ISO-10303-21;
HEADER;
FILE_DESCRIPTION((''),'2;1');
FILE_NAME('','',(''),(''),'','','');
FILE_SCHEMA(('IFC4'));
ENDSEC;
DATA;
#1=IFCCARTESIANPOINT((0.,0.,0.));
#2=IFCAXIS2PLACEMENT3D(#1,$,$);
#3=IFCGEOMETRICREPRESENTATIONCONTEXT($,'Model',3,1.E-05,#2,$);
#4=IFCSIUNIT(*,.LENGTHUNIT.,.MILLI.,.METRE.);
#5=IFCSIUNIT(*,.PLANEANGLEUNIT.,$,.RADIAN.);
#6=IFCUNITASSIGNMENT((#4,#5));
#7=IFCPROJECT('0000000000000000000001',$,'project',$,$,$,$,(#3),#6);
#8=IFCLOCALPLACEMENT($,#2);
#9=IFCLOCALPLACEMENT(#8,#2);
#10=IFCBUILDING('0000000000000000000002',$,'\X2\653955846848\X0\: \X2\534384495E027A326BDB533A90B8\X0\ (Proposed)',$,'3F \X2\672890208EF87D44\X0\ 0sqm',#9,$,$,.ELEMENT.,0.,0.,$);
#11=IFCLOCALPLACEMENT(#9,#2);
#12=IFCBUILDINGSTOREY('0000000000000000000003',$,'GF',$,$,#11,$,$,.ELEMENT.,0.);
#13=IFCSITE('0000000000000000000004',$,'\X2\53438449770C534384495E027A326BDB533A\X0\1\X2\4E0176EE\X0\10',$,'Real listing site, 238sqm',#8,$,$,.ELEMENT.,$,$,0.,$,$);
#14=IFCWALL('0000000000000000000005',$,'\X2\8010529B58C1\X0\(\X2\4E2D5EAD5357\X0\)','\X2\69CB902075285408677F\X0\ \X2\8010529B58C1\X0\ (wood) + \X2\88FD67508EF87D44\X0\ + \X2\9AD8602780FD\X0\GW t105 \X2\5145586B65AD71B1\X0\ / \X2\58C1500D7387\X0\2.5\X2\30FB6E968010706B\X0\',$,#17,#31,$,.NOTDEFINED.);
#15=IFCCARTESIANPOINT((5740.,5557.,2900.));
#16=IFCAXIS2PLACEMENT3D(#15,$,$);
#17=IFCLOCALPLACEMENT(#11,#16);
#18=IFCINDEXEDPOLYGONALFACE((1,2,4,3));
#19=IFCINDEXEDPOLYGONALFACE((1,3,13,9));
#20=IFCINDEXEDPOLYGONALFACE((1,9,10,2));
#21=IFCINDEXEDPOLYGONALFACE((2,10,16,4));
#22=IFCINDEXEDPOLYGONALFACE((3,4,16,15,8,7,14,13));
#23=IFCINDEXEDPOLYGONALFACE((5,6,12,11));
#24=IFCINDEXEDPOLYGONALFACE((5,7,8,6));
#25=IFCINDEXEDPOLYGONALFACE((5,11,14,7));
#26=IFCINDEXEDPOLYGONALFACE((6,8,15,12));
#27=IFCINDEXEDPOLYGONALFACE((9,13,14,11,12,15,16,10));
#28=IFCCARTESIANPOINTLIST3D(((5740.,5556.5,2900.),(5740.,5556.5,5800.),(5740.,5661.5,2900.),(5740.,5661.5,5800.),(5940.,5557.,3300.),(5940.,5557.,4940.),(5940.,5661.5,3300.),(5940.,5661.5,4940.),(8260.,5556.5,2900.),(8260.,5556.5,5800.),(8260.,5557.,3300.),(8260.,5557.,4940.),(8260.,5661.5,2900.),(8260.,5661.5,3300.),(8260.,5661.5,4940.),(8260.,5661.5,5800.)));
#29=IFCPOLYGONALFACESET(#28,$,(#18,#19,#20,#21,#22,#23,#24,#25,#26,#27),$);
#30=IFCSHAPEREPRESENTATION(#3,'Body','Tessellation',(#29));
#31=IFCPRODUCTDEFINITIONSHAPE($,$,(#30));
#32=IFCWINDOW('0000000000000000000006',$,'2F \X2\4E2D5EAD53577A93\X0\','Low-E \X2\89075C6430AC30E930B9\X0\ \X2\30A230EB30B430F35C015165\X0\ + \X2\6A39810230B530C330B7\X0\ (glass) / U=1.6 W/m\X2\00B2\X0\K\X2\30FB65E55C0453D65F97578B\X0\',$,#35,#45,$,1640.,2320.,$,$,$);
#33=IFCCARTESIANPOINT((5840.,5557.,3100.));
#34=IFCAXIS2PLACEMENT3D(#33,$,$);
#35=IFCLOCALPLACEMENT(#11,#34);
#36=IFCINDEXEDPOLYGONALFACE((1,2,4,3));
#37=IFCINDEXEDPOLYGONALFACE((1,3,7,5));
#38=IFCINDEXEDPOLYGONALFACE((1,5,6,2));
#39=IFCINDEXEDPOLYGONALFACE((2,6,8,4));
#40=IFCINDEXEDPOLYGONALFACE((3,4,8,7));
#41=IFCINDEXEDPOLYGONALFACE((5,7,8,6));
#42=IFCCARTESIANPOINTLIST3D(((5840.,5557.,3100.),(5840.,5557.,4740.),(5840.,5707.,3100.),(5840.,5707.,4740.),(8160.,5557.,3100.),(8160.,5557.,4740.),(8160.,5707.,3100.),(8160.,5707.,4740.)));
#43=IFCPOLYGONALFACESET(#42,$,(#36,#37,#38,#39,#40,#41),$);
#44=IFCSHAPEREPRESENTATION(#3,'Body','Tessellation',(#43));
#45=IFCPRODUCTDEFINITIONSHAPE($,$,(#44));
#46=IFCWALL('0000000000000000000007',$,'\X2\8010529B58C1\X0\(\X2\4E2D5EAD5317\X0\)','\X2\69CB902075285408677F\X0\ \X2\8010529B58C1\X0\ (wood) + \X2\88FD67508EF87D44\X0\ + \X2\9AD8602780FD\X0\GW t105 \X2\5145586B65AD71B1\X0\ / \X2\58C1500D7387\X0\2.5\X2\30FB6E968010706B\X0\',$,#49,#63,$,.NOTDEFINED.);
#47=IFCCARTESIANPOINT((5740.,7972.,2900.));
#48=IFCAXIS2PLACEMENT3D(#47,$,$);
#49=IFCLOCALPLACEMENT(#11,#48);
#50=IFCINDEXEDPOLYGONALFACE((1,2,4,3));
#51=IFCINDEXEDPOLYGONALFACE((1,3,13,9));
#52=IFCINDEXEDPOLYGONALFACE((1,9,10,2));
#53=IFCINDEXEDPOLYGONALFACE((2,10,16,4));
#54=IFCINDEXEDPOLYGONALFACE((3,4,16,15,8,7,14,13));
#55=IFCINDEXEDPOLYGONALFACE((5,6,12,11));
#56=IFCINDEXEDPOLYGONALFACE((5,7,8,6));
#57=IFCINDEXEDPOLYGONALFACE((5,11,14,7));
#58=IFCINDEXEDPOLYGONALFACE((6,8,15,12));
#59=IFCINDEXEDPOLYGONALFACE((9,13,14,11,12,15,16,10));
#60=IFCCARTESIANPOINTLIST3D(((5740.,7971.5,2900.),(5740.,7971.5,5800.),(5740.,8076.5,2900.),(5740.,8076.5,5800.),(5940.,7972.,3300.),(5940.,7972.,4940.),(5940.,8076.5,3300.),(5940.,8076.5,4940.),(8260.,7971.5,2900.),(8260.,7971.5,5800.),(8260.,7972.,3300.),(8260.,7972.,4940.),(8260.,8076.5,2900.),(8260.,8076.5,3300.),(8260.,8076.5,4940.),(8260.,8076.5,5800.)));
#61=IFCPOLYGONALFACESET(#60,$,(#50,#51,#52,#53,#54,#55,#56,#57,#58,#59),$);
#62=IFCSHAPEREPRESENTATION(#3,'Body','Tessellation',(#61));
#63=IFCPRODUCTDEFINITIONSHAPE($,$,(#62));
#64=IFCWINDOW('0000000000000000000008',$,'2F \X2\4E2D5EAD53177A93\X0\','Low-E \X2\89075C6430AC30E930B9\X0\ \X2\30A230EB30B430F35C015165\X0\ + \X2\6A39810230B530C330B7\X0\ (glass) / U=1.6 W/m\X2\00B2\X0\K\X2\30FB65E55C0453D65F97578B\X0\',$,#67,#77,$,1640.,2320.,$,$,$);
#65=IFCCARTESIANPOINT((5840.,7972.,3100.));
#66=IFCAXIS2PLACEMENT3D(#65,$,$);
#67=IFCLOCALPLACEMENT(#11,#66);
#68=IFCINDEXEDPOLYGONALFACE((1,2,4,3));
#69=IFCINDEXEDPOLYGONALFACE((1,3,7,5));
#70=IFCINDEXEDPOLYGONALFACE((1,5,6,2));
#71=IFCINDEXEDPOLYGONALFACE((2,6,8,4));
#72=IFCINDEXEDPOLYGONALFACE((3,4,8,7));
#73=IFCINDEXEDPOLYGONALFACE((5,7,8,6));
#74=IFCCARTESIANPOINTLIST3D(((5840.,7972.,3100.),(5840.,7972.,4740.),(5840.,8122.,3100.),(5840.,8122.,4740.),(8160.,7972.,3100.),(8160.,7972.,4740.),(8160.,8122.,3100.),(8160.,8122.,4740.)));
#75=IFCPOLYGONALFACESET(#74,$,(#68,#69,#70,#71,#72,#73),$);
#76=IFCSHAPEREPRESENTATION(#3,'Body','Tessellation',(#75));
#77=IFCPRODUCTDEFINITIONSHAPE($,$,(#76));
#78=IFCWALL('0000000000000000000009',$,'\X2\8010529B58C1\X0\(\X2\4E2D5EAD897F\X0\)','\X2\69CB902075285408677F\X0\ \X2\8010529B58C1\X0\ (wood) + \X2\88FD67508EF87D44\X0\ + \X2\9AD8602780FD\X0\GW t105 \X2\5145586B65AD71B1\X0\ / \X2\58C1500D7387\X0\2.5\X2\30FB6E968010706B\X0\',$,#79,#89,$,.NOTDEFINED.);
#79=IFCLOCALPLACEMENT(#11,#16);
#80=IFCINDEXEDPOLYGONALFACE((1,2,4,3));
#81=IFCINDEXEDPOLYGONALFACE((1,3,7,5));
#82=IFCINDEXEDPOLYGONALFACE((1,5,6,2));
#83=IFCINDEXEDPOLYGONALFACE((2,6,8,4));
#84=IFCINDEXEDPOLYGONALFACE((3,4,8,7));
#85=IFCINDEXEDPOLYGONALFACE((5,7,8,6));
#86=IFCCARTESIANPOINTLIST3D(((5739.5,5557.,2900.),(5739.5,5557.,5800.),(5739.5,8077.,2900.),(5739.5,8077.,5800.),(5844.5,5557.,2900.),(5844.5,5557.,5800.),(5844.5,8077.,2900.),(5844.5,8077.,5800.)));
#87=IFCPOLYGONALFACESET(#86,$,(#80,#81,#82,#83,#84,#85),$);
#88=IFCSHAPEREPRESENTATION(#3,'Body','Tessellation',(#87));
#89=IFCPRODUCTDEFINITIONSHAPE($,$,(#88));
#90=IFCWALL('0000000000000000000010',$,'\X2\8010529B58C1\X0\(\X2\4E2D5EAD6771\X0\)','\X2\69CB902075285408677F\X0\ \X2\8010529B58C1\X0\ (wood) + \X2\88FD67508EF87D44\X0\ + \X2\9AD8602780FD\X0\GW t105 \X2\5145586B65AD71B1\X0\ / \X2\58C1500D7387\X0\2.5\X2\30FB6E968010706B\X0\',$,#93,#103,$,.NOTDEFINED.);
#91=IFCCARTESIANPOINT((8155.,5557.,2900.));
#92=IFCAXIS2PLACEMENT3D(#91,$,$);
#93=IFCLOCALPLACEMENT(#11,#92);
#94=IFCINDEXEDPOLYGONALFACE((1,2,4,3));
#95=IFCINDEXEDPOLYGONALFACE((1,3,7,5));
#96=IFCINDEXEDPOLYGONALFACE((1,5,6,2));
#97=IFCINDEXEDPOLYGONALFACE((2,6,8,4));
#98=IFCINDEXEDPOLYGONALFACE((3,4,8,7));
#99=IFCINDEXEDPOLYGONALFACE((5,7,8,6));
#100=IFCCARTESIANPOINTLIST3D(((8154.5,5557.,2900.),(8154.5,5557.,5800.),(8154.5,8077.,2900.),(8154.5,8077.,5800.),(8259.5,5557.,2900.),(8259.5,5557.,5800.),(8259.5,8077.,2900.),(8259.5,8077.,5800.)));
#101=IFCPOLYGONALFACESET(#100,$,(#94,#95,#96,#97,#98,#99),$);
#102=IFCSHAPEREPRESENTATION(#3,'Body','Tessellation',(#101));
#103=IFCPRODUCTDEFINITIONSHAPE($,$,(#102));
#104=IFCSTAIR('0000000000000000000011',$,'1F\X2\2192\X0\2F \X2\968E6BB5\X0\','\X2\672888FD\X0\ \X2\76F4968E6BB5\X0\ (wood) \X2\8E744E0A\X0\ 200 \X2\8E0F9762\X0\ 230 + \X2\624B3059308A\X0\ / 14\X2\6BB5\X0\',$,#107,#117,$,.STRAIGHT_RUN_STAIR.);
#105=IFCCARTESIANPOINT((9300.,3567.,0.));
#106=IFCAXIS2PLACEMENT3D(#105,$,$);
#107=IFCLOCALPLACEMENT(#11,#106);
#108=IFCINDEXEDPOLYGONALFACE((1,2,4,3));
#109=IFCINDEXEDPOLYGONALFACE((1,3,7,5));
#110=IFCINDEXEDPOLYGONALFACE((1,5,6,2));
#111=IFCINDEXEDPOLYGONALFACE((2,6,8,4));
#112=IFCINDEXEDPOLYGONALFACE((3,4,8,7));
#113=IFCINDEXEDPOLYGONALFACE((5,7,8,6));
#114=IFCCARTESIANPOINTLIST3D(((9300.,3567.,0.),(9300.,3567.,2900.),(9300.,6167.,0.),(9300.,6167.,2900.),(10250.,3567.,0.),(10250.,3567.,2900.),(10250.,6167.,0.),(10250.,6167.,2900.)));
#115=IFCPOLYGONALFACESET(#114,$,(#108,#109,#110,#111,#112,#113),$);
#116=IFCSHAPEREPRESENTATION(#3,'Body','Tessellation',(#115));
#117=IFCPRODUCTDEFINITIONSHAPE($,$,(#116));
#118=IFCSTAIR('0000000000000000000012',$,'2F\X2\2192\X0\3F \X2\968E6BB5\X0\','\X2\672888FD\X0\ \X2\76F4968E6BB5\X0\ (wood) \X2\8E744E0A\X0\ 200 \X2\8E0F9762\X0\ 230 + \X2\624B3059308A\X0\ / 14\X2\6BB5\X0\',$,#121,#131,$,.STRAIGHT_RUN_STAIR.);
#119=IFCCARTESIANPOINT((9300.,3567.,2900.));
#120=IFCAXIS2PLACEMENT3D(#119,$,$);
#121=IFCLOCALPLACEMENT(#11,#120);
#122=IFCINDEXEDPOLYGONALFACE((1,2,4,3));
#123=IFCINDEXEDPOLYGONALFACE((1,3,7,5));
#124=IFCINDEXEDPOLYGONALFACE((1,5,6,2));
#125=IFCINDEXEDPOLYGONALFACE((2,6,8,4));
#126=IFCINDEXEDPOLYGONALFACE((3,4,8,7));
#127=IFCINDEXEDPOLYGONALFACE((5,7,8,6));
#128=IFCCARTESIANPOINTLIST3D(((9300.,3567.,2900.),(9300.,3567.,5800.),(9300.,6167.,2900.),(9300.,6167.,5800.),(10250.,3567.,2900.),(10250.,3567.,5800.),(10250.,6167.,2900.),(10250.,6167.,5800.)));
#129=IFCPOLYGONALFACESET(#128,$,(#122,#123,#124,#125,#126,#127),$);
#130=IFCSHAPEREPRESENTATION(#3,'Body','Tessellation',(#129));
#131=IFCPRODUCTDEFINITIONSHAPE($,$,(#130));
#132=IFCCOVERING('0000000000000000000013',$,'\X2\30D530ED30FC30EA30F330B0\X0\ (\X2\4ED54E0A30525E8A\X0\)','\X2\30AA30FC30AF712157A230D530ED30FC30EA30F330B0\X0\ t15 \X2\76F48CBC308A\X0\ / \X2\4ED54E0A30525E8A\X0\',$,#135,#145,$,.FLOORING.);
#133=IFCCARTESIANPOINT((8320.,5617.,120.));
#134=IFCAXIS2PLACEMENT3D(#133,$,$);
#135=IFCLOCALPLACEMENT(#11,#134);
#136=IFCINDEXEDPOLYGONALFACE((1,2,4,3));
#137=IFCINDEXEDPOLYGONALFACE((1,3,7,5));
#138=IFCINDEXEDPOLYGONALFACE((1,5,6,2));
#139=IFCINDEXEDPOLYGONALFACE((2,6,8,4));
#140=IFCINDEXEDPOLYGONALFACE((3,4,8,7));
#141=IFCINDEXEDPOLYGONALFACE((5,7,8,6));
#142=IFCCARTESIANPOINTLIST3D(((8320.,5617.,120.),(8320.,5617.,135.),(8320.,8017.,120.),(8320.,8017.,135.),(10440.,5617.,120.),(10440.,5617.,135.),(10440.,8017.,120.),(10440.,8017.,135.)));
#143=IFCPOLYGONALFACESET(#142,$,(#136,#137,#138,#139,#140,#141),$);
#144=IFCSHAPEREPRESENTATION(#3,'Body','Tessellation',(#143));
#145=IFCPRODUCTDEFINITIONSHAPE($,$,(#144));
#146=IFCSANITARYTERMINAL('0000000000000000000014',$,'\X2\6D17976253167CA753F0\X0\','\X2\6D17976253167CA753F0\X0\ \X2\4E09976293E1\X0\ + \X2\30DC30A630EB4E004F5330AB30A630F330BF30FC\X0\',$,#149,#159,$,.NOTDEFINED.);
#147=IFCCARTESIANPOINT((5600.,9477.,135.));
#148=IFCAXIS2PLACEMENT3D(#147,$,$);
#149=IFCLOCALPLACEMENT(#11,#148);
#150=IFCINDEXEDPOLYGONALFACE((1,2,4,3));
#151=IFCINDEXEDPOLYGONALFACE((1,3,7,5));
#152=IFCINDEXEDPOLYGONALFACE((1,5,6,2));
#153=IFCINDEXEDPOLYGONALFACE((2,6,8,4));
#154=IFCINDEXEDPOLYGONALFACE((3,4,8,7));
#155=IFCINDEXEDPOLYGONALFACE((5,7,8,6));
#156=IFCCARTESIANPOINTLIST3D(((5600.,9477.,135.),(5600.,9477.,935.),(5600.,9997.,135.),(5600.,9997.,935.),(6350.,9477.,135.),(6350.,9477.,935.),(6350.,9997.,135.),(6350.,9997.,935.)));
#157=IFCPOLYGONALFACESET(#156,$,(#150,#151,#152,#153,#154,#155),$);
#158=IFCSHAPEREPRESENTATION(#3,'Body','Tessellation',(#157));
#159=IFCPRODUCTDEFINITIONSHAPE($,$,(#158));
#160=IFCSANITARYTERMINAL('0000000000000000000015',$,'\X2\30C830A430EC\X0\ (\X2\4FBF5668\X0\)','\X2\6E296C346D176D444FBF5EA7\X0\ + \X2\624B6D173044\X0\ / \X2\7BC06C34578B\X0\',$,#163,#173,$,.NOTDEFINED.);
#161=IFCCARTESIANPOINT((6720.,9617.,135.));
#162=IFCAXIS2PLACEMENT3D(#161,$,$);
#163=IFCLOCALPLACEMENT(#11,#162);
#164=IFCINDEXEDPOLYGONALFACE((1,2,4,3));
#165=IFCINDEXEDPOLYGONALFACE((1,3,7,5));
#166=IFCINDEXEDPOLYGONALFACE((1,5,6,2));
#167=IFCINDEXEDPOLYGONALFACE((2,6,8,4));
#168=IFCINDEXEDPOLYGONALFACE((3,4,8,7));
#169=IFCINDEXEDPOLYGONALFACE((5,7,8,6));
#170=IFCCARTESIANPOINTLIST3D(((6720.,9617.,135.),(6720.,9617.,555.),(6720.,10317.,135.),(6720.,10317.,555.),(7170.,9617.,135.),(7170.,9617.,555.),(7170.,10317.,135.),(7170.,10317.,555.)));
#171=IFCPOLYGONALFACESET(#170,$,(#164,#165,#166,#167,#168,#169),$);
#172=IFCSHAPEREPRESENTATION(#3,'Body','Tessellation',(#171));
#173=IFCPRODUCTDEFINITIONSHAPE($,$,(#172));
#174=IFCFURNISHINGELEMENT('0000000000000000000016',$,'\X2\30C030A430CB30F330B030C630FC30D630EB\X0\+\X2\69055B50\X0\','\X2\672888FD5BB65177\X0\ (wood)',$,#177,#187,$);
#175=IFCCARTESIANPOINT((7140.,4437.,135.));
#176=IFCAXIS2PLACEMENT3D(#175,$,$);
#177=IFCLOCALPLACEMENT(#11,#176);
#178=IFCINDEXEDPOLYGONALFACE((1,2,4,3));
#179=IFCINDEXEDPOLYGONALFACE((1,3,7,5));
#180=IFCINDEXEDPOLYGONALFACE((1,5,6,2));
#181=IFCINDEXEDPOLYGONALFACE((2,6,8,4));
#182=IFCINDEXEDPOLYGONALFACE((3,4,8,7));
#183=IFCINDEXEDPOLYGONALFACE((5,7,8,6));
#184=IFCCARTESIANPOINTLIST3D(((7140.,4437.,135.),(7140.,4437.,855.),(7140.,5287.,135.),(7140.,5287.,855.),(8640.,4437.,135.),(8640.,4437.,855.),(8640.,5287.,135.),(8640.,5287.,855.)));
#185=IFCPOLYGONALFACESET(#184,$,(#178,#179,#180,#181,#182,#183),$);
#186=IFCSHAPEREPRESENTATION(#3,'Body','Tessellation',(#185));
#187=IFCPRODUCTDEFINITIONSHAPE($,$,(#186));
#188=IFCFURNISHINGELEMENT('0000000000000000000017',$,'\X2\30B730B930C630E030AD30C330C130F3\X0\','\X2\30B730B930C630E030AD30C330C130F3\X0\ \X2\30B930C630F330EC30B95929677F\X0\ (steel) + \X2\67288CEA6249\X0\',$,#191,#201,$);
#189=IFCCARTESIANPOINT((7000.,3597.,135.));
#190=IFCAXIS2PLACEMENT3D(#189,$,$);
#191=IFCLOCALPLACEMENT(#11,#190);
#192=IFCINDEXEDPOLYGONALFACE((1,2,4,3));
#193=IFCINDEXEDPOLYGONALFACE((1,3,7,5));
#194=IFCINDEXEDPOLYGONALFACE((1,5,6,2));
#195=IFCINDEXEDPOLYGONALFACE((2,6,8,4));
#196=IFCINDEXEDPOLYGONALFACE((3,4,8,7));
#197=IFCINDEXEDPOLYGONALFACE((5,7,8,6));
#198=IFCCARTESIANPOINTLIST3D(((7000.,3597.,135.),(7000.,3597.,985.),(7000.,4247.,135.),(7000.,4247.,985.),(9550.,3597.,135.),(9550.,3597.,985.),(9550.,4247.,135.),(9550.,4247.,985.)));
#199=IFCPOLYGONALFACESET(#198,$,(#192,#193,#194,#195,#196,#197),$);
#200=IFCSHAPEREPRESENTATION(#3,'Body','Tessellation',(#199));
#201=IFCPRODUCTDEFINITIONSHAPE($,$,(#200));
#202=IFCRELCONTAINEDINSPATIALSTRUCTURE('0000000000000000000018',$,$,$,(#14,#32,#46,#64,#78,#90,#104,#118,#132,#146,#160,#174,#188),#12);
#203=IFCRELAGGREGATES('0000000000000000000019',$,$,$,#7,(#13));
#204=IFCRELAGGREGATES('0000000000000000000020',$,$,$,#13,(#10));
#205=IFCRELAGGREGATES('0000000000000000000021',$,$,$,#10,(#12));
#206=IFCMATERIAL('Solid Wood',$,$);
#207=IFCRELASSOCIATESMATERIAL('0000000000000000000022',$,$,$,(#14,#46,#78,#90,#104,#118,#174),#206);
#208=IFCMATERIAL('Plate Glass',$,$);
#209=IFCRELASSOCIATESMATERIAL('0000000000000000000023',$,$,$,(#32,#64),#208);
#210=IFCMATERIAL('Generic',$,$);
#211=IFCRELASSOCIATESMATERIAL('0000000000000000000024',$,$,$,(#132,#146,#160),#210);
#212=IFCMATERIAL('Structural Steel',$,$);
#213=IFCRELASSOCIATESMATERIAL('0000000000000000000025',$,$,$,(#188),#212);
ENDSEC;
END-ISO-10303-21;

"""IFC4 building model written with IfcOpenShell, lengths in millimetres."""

from ifc_helpers import new_model, si_unit, frame, frame_2d, origin, place, context, project, spatial, rectangle, extrude, material, element, fill, save


model = new_model("IFC4")

# Units and contexts
model_context = context("Model", 3, precision=1e-05, world=origin())
ifc_project = project(units=[si_unit("LENGTHUNIT", "METRE", prefix="MILLI"), si_unit("PLANEANGLEUNIT", "RADIAN")], contexts=[model_context])

# Site, building, storey
site_placement = place(None, origin())
site = spatial("IfcSite", under=ifc_project, at=site_placement, Name="千葉県千葉市稲毛区1丁目10", ObjectType="Real listing site, 238sqm", CompositionType="ELEMENT", RefElevation=0.0)
building_placement = place(site_placement, origin())
building = spatial("IfcBuilding", under=site, at=building_placement, Name="改善案: 千葉市稲毛区邸 (Proposed)", ObjectType="3F 木造軸組 0sqm", CompositionType="ELEMENT", ElevationOfRefHeight=0.0, ElevationOfTerrain=0.0)
storey_placement = place(building_placement, origin())
storey = spatial("IfcBuildingStorey", under=building, at=storey_placement, Name="GF", CompositionType="ELEMENT", Elevation=0.0)

# Shared definitions
ifc_material_1 = material(Name="Solid Wood")

# Shared definitions
ifc_material_2 = material(Name="Plate Glass")

# Walls, openings, windows
wall_1_placement = place(storey_placement, frame((5740.0, 5557.0, 2900.0)))
wall_1 = element("IfcWall", 1, at=wall_1_placement, inside=storey, material=ifc_material_1, Name="耐力壁(中庭南)", Description="構造用合板 耐力壁 (wood) + 製材軸組 + 高性能GW t105 充填断熱 / 壁倍率2.5・準耐火", PredefinedType="NOTDEFINED", context=model_context, shape_type="SweptSolid", body=[
    extrude(rectangle(XDim=2520.0, YDim=105.0, at=frame_2d((1260.0, 52.0))), frame((5740.0, 5557.0, 2900.0)), (0.0, 0.0, 1.0), 2900.0),
])
opening_1_placement = place(storey_placement, frame((5840.0, 5557.0, 3100.0)))
opening_1 = element("IfcOpeningElement", 2, at=opening_1_placement, cuts=wall_1, PredefinedType="NOTDEFINED", context=model_context, shape_type="SweptSolid", body=[
    extrude(rectangle(XDim=2320.0, YDim=150.0, at=frame_2d((1160.0, 75.0))), frame((5840.0, 5557.0, 3100.0)), (0.0, 0.0, 1.0), 1640.0),
])
window_1_placement = place(storey_placement, frame((5840.0, 5557.0, 3100.0)))
window_1 = element("IfcWindow", 3, at=window_1_placement, inside=storey, material=ifc_material_2, Name="2F 中庭南窓", Description="Low-E 複層ガラス アルゴン封入 + 樹脂サッシ (glass) / U=1.6 W/m²K・日射取得型", OverallHeight=1640.0, OverallWidth=2320.0, context=model_context, shape_type="SweptSolid", body=[
    extrude(rectangle(XDim=2320.0, YDim=150.0, at=frame_2d((1160.0, 75.0))), frame((5840.0, 5557.0, 3100.0)), (0.0, 0.0, 1.0), 1640.0),
])
fill(opening_1, window_1)
wall_2_placement = place(storey_placement, frame((5740.0, 7972.0, 2900.0)))
wall_2 = element("IfcWall", 4, at=wall_2_placement, inside=storey, material=ifc_material_1, Name="耐力壁(中庭北)", Description="構造用合板 耐力壁 (wood) + 製材軸組 + 高性能GW t105 充填断熱 / 壁倍率2.5・準耐火", PredefinedType="NOTDEFINED", context=model_context, shape_type="SweptSolid", body=[
    extrude(rectangle(XDim=2520.0, YDim=105.0, at=frame_2d((1260.0, 52.0))), frame((5740.0, 7972.0, 2900.0)), (0.0, 0.0, 1.0), 2900.0),
])
opening_2_placement = place(storey_placement, frame((5840.0, 7972.0, 3100.0)))
opening_2 = element("IfcOpeningElement", 5, at=opening_2_placement, cuts=wall_2, PredefinedType="NOTDEFINED", context=model_context, shape_type="SweptSolid", body=[
    extrude(rectangle(XDim=2320.0, YDim=150.0, at=frame_2d((1160.0, 75.0))), frame((5840.0, 7972.0, 3100.0)), (0.0, 0.0, 1.0), 1640.0),
])
window_2_placement = place(storey_placement, frame((5840.0, 7972.0, 3100.0)))
window_2 = element("IfcWindow", 6, at=window_2_placement, inside=storey, material=ifc_material_2, Name="2F 中庭北窓", Description="Low-E 複層ガラス アルゴン封入 + 樹脂サッシ (glass) / U=1.6 W/m²K・日射取得型", OverallHeight=1640.0, OverallWidth=2320.0, context=model_context, shape_type="SweptSolid", body=[
    extrude(rectangle(XDim=2320.0, YDim=150.0, at=frame_2d((1160.0, 75.0))), frame((5840.0, 7972.0, 3100.0)), (0.0, 0.0, 1.0), 1640.0),
])
fill(opening_2, window_2)

# Walls
wall_3_placement = place(storey_placement, frame((5740.0, 5557.0, 2900.0)))
element("IfcWall", 7, at=wall_3_placement, inside=storey, material=ifc_material_1, Name="耐力壁(中庭西)", Description="構造用合板 耐力壁 (wood) + 製材軸組 + 高性能GW t105 充填断熱 / 壁倍率2.5・準耐火", PredefinedType="NOTDEFINED", context=model_context, shape_type="SweptSolid", body=[
    extrude(rectangle(XDim=105.0, YDim=2520.0, at=frame_2d((52.0, 1260.0))), frame((5740.0, 5557.0, 2900.0)), (0.0, 0.0, 1.0), 2900.0),
])
wall_4_placement = place(storey_placement, frame((8155.0, 5557.0, 2900.0)))
element("IfcWall", 8, at=wall_4_placement, inside=storey, material=ifc_material_1, Name="耐力壁(中庭東)", Description="構造用合板 耐力壁 (wood) + 製材軸組 + 高性能GW t105 充填断熱 / 壁倍率2.5・準耐火", PredefinedType="NOTDEFINED", context=model_context, shape_type="SweptSolid", body=[
    extrude(rectangle(XDim=105.0, YDim=2520.0, at=frame_2d((52.0, 1260.0))), frame((8155.0, 5557.0, 2900.0)), (0.0, 0.0, 1.0), 2900.0),
])

# Stairs
stair_1_placement = place(storey_placement, frame((9300.0, 3567.0, 0.0)))
element("IfcStair", 9, at=stair_1_placement, inside=storey, material=ifc_material_1, Name="1F→2F 階段", Description="木製 直階段 (wood) 蹴上 200 踏面 230 + 手すり / 14段", PredefinedType="STRAIGHT_RUN_STAIR", context=model_context, shape_type="SweptSolid", body=[
    extrude(rectangle(XDim=950.0, YDim=2600.0, at=frame_2d((475.0, 1300.0))), frame((9300.0, 3567.0, 0.0)), (0.0, 0.0, 1.0), 2900.0),
])
stair_2_placement = place(storey_placement, frame((9300.0, 3567.0, 2900.0)))
element("IfcStair", 10, at=stair_2_placement, inside=storey, material=ifc_material_1, Name="2F→3F 階段", Description="木製 直階段 (wood) 蹴上 200 踏面 230 + 手すり / 14段", PredefinedType="STRAIGHT_RUN_STAIR", context=model_context, shape_type="SweptSolid", body=[
    extrude(rectangle(XDim=950.0, YDim=2600.0, at=frame_2d((475.0, 1300.0))), frame((9300.0, 3567.0, 2900.0)), (0.0, 0.0, 1.0), 2900.0),
])

# Covering
ifc_material_3 = material(Name="Generic")
covering_placement = place(storey_placement, frame((8320.0, 5617.0, 120.0)))
element("IfcCovering", 11, at=covering_placement, inside=storey, material=ifc_material_3, Name="フローリング (仕上げ床)", Description="オーク無垢フローリング t15 直貼り / 仕上げ床", PredefinedType="FLOORING", context=model_context, shape_type="SweptSolid", body=[
    extrude(rectangle(XDim=2120.0, YDim=2400.0, at=frame_2d((1060.0, 1200.0))), frame((8320.0, 5617.0, 120.0)), (0.0, 0.0, 1.0), 15.0),
])

# Sanitary terminals
sanitary_terminal_1_placement = place(storey_placement, frame((5600.0, 9477.0, 135.0)))
element("IfcSanitaryTerminal", 12, at=sanitary_terminal_1_placement, inside=storey, material=ifc_material_3, Name="洗面化粧台", Description="洗面化粧台 三面鏡 + ボウル一体カウンター", PredefinedType="NOTDEFINED", context=model_context, shape_type="SweptSolid", body=[
    extrude(rectangle(XDim=750.0, YDim=520.0, at=frame_2d((375.0, 260.0))), frame((5600.0, 9477.0, 135.0)), (0.0, 0.0, 1.0), 800.0),
])
sanitary_terminal_2_placement = place(storey_placement, frame((6720.0, 9617.0, 135.0)))
element("IfcSanitaryTerminal", 13, at=sanitary_terminal_2_placement, inside=storey, material=ifc_material_3, Name="トイレ (便器)", Description="温水洗浄便座 + 手洗い / 節水型", PredefinedType="NOTDEFINED", context=model_context, shape_type="SweptSolid", body=[
    extrude(rectangle(XDim=450.0, YDim=700.0, at=frame_2d((225.0, 350.0))), frame((6720.0, 9617.0, 135.0)), (0.0, 0.0, 1.0), 420.0),
])

# Furnishing elements
furnishing_1_placement = place(storey_placement, frame((7140.0, 4437.0, 135.0)))
element("IfcFurnishingElement", 14, at=furnishing_1_placement, inside=storey, material=ifc_material_1, Name="ダイニングテーブル+椅子", Description="木製家具 (wood)", context=model_context, shape_type="SweptSolid", body=[
    extrude(rectangle(XDim=1500.0, YDim=850.0, at=frame_2d((750.0, 425.0))), frame((7140.0, 4437.0, 135.0)), (0.0, 0.0, 1.0), 720.0),
])
ifc_material_4 = material(Name="Structural Steel")
furnishing_2_placement = place(storey_placement, frame((7000.0, 3597.0, 135.0)))
element("IfcFurnishingElement", 15, at=furnishing_2_placement, inside=storey, material=ifc_material_4, Name="システムキッチン", Description="システムキッチン ステンレス天板 (steel) + 木質扉", context=model_context, shape_type="SweptSolid", body=[
    extrude(rectangle(XDim=2550.0, YDim=650.0, at=frame_2d((1275.0, 325.0))), frame((7000.0, 3597.0, 135.0)), (0.0, 0.0, 1.0), 850.0),
])

save(model, "model.ifc")
